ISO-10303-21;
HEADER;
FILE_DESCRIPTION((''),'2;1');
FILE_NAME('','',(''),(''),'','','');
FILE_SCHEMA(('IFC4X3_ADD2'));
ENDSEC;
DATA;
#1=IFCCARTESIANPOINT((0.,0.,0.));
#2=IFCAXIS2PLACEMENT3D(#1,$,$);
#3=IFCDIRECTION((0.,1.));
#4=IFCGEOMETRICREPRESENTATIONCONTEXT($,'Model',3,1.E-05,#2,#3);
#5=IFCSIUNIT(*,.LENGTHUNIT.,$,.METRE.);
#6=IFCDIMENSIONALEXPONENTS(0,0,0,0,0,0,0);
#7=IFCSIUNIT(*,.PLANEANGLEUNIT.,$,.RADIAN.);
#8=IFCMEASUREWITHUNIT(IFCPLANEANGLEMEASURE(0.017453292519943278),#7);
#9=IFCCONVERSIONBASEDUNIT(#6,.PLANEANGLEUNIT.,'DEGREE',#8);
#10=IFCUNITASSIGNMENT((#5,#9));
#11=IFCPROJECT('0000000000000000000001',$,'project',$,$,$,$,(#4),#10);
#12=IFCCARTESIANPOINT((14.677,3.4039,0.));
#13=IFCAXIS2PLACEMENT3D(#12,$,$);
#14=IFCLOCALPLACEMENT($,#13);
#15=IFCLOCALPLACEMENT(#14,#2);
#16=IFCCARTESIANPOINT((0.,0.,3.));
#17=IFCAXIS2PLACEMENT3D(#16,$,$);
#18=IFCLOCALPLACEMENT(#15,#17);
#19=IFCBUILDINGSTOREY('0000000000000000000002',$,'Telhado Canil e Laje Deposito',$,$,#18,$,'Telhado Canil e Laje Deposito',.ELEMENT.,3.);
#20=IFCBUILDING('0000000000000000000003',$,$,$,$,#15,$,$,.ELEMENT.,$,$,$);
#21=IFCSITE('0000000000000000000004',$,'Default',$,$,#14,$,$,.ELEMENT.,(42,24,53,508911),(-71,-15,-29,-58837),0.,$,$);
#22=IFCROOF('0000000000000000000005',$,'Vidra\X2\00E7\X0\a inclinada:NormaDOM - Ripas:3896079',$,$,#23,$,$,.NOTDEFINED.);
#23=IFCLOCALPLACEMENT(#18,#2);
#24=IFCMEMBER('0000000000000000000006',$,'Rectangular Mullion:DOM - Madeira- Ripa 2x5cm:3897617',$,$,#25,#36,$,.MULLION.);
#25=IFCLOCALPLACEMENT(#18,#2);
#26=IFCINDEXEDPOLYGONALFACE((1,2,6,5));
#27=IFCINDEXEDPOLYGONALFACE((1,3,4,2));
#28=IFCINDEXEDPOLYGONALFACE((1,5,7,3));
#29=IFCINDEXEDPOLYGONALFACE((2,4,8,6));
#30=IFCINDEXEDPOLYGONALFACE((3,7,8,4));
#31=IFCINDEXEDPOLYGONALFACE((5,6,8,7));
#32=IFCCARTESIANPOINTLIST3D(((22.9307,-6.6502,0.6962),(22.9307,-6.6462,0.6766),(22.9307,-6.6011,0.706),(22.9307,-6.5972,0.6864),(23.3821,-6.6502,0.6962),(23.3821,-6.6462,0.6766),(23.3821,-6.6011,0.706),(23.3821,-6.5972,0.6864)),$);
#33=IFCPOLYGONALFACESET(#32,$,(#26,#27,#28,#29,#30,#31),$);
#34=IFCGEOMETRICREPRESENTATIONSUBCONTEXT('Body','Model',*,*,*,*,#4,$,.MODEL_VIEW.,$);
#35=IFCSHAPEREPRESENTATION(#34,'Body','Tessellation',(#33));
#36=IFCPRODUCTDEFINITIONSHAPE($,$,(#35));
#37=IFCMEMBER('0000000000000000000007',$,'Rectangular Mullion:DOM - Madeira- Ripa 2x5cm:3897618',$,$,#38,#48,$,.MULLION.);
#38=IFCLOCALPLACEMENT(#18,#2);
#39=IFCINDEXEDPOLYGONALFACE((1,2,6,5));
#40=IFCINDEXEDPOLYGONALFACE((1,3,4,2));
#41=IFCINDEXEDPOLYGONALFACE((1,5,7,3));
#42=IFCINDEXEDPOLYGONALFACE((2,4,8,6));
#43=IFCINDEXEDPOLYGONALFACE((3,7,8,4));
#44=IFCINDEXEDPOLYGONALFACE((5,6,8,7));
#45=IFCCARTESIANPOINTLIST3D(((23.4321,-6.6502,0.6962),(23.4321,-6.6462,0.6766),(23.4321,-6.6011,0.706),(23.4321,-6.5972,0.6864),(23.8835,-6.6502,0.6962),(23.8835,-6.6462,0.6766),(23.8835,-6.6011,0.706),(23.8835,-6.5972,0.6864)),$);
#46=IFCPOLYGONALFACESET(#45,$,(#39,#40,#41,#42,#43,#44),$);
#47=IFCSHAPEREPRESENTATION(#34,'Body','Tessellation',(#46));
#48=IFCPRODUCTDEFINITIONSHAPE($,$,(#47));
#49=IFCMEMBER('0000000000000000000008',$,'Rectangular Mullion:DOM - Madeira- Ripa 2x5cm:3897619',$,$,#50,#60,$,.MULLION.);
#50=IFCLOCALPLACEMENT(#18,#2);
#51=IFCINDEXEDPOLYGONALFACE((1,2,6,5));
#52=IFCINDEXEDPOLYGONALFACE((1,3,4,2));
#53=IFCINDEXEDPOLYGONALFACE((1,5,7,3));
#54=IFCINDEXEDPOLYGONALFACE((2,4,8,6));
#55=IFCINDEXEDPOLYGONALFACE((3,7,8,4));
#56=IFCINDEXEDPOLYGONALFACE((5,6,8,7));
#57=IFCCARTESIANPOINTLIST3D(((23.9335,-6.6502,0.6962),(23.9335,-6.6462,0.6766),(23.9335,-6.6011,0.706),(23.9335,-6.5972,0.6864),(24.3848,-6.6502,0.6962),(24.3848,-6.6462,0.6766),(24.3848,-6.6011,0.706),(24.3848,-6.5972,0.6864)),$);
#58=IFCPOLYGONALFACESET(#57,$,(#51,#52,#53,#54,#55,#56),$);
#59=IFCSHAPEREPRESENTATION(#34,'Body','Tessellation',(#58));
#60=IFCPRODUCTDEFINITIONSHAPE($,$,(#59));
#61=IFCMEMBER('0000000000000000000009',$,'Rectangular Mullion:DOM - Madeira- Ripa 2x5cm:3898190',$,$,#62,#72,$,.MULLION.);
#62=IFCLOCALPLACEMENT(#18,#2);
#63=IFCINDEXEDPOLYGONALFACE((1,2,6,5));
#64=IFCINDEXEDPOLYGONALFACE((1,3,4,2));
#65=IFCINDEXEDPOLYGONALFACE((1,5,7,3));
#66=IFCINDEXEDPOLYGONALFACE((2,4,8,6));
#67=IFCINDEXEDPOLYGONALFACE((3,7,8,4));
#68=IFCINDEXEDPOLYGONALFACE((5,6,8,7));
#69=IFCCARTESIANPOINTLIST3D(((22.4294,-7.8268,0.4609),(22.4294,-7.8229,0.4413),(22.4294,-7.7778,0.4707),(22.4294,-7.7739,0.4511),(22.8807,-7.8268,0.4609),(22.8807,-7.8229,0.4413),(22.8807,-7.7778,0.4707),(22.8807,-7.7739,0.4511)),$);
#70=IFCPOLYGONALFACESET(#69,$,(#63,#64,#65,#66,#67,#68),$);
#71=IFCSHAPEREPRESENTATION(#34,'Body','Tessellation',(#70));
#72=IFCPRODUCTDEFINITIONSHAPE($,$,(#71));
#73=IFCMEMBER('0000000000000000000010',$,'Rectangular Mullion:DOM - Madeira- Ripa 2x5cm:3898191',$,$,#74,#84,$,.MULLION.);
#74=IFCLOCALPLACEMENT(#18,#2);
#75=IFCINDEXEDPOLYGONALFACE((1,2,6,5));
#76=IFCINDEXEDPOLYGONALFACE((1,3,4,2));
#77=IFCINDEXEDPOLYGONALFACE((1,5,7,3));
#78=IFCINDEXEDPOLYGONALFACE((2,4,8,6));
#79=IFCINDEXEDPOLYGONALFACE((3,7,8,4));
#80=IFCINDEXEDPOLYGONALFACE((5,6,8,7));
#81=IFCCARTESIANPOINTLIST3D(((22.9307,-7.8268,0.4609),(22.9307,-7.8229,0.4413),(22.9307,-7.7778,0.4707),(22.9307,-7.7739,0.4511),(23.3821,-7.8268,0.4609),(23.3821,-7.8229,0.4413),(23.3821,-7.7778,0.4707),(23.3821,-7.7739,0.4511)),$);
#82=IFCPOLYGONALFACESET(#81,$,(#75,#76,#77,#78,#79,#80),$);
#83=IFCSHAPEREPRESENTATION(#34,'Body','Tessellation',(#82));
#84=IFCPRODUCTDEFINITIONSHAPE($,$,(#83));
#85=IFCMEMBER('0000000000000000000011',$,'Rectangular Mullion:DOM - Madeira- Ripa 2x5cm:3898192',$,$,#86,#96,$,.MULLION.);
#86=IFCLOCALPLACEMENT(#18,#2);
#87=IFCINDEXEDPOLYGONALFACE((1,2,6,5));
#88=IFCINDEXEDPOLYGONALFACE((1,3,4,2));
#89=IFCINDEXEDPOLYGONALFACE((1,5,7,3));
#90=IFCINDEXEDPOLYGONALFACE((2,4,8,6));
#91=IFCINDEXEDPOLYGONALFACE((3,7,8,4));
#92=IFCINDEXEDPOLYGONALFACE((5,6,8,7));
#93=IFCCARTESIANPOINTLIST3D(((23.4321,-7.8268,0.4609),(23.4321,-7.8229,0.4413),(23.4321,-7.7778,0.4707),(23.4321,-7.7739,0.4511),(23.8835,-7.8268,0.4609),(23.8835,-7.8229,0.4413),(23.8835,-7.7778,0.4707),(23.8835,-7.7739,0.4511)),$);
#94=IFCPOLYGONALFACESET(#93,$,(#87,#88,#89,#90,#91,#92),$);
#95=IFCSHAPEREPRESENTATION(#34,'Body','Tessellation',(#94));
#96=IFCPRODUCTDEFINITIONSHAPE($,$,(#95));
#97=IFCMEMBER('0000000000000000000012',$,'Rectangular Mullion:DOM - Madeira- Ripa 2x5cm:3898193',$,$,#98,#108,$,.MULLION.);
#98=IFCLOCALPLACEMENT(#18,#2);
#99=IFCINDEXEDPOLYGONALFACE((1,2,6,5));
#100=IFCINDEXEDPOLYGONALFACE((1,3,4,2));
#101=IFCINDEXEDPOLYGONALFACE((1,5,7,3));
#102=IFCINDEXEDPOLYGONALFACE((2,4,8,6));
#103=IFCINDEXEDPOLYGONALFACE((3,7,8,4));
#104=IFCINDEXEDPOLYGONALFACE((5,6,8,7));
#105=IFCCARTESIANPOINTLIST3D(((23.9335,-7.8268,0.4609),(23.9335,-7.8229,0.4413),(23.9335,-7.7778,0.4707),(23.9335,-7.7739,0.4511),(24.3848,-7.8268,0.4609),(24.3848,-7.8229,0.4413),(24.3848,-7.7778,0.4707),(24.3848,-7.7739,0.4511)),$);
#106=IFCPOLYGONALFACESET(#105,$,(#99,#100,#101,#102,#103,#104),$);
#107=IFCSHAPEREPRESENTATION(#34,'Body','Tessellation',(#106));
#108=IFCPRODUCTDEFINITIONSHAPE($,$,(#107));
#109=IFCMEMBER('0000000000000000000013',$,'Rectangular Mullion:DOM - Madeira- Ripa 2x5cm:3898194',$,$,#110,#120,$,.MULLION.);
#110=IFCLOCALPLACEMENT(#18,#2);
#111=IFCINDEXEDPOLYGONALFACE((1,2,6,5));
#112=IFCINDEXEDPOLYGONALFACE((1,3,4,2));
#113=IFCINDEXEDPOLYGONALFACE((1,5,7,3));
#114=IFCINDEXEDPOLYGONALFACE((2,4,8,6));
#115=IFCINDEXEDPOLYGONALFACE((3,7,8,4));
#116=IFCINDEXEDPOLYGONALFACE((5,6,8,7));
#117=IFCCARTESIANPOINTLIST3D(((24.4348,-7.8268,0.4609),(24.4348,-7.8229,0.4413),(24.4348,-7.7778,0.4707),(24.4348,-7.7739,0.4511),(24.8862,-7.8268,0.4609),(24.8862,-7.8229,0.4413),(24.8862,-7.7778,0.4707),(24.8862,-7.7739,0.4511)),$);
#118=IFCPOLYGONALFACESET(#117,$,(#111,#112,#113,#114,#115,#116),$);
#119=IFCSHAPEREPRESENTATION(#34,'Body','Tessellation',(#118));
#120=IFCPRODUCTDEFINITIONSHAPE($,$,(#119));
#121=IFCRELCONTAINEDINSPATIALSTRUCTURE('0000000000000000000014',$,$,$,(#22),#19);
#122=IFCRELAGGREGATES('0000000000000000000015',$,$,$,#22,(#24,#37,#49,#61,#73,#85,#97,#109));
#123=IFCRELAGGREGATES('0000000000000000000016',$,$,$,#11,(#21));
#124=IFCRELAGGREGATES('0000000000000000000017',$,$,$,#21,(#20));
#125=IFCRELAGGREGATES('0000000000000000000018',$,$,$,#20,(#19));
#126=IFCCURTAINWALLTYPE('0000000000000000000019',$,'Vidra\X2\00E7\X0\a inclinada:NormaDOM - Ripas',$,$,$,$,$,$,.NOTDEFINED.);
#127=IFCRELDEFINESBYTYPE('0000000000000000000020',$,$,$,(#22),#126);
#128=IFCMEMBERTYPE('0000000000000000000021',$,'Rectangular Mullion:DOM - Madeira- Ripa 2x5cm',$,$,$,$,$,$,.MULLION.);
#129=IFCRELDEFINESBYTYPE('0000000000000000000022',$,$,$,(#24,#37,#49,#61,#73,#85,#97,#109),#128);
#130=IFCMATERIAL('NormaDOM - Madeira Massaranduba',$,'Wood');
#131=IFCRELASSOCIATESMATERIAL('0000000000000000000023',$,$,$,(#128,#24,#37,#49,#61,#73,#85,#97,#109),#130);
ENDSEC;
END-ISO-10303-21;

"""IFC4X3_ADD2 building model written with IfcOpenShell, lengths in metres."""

from ifc_helpers import new_model, entity, si_unit, converted_unit, direction, frame, origin, origin_2d_with_axis, place, context, subcontext, project, spatial, rectangle, extrude, source, transform, mapped, material, material_profile, profile_set, profile_usage, type_object, type_shapes, element, aggregate, save


model = new_model("IFC4X3_ADD2")

# Units and contexts
model_context = context("Model", 3, precision=1e-05, world=origin(), true_north=direction((0.0, 1.0)))
body_context = subcontext(model_context, "Body", "Model", "MODEL_VIEW")
ifc_project = project(units=[si_unit("LENGTHUNIT", "METRE"), converted_unit("PLANEANGLEUNIT", "DEGREE", entity("IfcPlaneAngleMeasure", 0.017453292519943278), si_unit("PLANEANGLEUNIT", "RADIAN"), dimensions=[0, 0, 0, 0, 0, 0, 0])], contexts=[model_context])

# Site, building, storey
site_placement = place(None, frame((14.677, 3.4039, 0.0)))
site = spatial("IfcSite", under=ifc_project, at=site_placement, Name="Default", CompositionType="ELEMENT", RefLatitude=(42, 24, 53, 508911), RefLongitude=(-71, -15, -29, -58837), RefElevation=0.0)
building_placement = place(site_placement, origin())
building = spatial("IfcBuilding", under=site, at=building_placement, CompositionType="ELEMENT")
storey_placement = place(building_placement, frame((0.0, 0.0, 3.0)))
storey = spatial("IfcBuildingStorey", under=building, at=storey_placement, Name="Telhado Canil e Laje Deposito", LongName="Telhado Canil e Laje Deposito", CompositionType="ELEMENT", Elevation=3.0)

# Roof, members
ifc_material = material(Name="NormaDOM - Madeira Massaranduba", Category="Wood")
ifc_material_profile_1 = material_profile(ifc_material, rectangle(XDim=0.05, YDim=0.02, at=origin_2d_with_axis()), Name="DOM - Madeira- Ripa 2x5cm")
ifc_profile_set_1 = profile_set([ifc_material_profile_1], Name="DOM - Madeira- Ripa 2x5cm")
ifc_profile_usage_1 = profile_usage(ifc_profile_set_1)
curtain_wall_type_1 = type_object("IfcCurtainWallType", Name="Vidraça inclinada:NormaDOM - Ripas", PredefinedType="NOTDEFINED")
roof_1_placement = place(storey_placement, frame((0.0, 0.0, -3.0)))
roof_1 = element("IfcRoof", 1, at=roof_1_placement, inside=storey, type_object=curtain_wall_type_1, Name="Vidraça inclinada:NormaDOM - Ripas:3896079", PredefinedType="NOTDEFINED")
member_type_1 = type_object("IfcMemberType", Name="Rectangular Mullion:DOM - Madeira- Ripa 2x5cm", PredefinedType="MULLION", material=ifc_profile_set_1)
shared_shape_1 = source(origin(), body_context, "Body", "SweptSolid", [
    extrude(rectangle(XDim=0.05, YDim=0.02, at=origin_2d_with_axis()), frame((0.025, 0.01, -0.4514), z_axis=(0.0, 0.0, 1.0), x_axis=(-1.0, 0.0, 0.0)), (0.0, 0.0, 1.0), 0.4514),
])
type_shapes(member_type_1, [shared_shape_1])
member_1_placement = place(roof_1_placement, frame((22.9307, -6.6502, 3.6962), z_axis=(-1.0, 0.0, 0.0), x_axis=(0.0, 0.980581, 0.196116)))
member_1 = element("IfcMember", 2, at=member_1_placement, type_object=member_type_1, material=ifc_profile_usage_1, Name="Rectangular Mullion:DOM - Madeira- Ripa 2x5cm:3897617", PredefinedType="MULLION", context=body_context, shape_type="MappedRepresentation", body=[
    mapped(shared_shape_1, transform((0.0, 0.0, 0.0), scale=1.0)),
])
member_2_placement = place(roof_1_placement, frame((23.4321, -6.6502, 3.6962), z_axis=(-1.0, 0.0, 0.0), x_axis=(0.0, 0.980581, 0.196116)))
member_2 = element("IfcMember", 3, at=member_2_placement, type_object=member_type_1, material=ifc_profile_usage_1, Name="Rectangular Mullion:DOM - Madeira- Ripa 2x5cm:3897618", PredefinedType="MULLION", context=body_context, shape_type="MappedRepresentation", body=[
    mapped(shared_shape_1, transform((0.0, 0.0, 0.0), scale=1.0)),
])
member_3_placement = place(roof_1_placement, frame((23.9335, -6.6502, 3.6962), z_axis=(-1.0, 0.0, 0.0), x_axis=(0.0, 0.980581, 0.196116)))
member_3 = element("IfcMember", 4, at=member_3_placement, type_object=member_type_1, material=ifc_profile_usage_1, Name="Rectangular Mullion:DOM - Madeira- Ripa 2x5cm:3897619", PredefinedType="MULLION", context=body_context, shape_type="MappedRepresentation", body=[
    mapped(shared_shape_1, transform((0.0, 0.0, 0.0), scale=1.0)),
])
member_4_placement = place(roof_1_placement, frame((22.4294, -7.8268, 3.4609), z_axis=(-1.0, 0.0, 0.0), x_axis=(0.0, 0.980581, 0.196116)))
member_4 = element("IfcMember", 5, at=member_4_placement, type_object=member_type_1, material=ifc_profile_usage_1, Name="Rectangular Mullion:DOM - Madeira- Ripa 2x5cm:3898190", PredefinedType="MULLION", context=body_context, shape_type="MappedRepresentation", body=[
    mapped(shared_shape_1, transform((0.0, 0.0, 0.0), scale=1.0)),
])
member_5_placement = place(roof_1_placement, frame((22.9307, -7.8268, 3.4609), z_axis=(-1.0, 0.0, 0.0), x_axis=(0.0, 0.980581, 0.196116)))
member_5 = element("IfcMember", 6, at=member_5_placement, type_object=member_type_1, material=ifc_profile_usage_1, Name="Rectangular Mullion:DOM - Madeira- Ripa 2x5cm:3898191", PredefinedType="MULLION", context=body_context, shape_type="MappedRepresentation", body=[
    mapped(shared_shape_1, transform((0.0, 0.0, 0.0), scale=1.0)),
])
member_6_placement = place(roof_1_placement, frame((23.4321, -7.8268, 3.4609), z_axis=(-1.0, 0.0, 0.0), x_axis=(0.0, 0.980581, 0.196116)))
member_6 = element("IfcMember", 7, at=member_6_placement, type_object=member_type_1, material=ifc_profile_usage_1, Name="Rectangular Mullion:DOM - Madeira- Ripa 2x5cm:3898192", PredefinedType="MULLION", context=body_context, shape_type="MappedRepresentation", body=[
    mapped(shared_shape_1, transform((0.0, 0.0, 0.0), scale=1.0)),
])
member_7_placement = place(roof_1_placement, frame((23.9335, -7.8268, 3.4609), z_axis=(-1.0, 0.0, 0.0), x_axis=(0.0, 0.980581, 0.196116)))
member_7 = element("IfcMember", 8, at=member_7_placement, type_object=member_type_1, material=ifc_profile_usage_1, Name="Rectangular Mullion:DOM - Madeira- Ripa 2x5cm:3898193", PredefinedType="MULLION", context=body_context, shape_type="MappedRepresentation", body=[
    mapped(shared_shape_1, transform((0.0, 0.0, 0.0), scale=1.0)),
])
member_8_placement = place(roof_1_placement, frame((24.4348, -7.8268, 3.4609), z_axis=(-1.0, 0.0, 0.0), x_axis=(0.0, 0.980581, 0.196116)))
member_8 = element("IfcMember", 9, at=member_8_placement, type_object=member_type_1, material=ifc_profile_usage_1, Name="Rectangular Mullion:DOM - Madeira- Ripa 2x5cm:3898194", PredefinedType="MULLION", context=body_context, shape_type="MappedRepresentation", body=[
    mapped(shared_shape_1, transform((0.0, 0.0, 0.0), scale=1.0)),
])
aggregate(roof_1, [member_1, member_2, member_3, member_4, member_5, member_6, member_7, member_8])

save(model, "model.ifc")
